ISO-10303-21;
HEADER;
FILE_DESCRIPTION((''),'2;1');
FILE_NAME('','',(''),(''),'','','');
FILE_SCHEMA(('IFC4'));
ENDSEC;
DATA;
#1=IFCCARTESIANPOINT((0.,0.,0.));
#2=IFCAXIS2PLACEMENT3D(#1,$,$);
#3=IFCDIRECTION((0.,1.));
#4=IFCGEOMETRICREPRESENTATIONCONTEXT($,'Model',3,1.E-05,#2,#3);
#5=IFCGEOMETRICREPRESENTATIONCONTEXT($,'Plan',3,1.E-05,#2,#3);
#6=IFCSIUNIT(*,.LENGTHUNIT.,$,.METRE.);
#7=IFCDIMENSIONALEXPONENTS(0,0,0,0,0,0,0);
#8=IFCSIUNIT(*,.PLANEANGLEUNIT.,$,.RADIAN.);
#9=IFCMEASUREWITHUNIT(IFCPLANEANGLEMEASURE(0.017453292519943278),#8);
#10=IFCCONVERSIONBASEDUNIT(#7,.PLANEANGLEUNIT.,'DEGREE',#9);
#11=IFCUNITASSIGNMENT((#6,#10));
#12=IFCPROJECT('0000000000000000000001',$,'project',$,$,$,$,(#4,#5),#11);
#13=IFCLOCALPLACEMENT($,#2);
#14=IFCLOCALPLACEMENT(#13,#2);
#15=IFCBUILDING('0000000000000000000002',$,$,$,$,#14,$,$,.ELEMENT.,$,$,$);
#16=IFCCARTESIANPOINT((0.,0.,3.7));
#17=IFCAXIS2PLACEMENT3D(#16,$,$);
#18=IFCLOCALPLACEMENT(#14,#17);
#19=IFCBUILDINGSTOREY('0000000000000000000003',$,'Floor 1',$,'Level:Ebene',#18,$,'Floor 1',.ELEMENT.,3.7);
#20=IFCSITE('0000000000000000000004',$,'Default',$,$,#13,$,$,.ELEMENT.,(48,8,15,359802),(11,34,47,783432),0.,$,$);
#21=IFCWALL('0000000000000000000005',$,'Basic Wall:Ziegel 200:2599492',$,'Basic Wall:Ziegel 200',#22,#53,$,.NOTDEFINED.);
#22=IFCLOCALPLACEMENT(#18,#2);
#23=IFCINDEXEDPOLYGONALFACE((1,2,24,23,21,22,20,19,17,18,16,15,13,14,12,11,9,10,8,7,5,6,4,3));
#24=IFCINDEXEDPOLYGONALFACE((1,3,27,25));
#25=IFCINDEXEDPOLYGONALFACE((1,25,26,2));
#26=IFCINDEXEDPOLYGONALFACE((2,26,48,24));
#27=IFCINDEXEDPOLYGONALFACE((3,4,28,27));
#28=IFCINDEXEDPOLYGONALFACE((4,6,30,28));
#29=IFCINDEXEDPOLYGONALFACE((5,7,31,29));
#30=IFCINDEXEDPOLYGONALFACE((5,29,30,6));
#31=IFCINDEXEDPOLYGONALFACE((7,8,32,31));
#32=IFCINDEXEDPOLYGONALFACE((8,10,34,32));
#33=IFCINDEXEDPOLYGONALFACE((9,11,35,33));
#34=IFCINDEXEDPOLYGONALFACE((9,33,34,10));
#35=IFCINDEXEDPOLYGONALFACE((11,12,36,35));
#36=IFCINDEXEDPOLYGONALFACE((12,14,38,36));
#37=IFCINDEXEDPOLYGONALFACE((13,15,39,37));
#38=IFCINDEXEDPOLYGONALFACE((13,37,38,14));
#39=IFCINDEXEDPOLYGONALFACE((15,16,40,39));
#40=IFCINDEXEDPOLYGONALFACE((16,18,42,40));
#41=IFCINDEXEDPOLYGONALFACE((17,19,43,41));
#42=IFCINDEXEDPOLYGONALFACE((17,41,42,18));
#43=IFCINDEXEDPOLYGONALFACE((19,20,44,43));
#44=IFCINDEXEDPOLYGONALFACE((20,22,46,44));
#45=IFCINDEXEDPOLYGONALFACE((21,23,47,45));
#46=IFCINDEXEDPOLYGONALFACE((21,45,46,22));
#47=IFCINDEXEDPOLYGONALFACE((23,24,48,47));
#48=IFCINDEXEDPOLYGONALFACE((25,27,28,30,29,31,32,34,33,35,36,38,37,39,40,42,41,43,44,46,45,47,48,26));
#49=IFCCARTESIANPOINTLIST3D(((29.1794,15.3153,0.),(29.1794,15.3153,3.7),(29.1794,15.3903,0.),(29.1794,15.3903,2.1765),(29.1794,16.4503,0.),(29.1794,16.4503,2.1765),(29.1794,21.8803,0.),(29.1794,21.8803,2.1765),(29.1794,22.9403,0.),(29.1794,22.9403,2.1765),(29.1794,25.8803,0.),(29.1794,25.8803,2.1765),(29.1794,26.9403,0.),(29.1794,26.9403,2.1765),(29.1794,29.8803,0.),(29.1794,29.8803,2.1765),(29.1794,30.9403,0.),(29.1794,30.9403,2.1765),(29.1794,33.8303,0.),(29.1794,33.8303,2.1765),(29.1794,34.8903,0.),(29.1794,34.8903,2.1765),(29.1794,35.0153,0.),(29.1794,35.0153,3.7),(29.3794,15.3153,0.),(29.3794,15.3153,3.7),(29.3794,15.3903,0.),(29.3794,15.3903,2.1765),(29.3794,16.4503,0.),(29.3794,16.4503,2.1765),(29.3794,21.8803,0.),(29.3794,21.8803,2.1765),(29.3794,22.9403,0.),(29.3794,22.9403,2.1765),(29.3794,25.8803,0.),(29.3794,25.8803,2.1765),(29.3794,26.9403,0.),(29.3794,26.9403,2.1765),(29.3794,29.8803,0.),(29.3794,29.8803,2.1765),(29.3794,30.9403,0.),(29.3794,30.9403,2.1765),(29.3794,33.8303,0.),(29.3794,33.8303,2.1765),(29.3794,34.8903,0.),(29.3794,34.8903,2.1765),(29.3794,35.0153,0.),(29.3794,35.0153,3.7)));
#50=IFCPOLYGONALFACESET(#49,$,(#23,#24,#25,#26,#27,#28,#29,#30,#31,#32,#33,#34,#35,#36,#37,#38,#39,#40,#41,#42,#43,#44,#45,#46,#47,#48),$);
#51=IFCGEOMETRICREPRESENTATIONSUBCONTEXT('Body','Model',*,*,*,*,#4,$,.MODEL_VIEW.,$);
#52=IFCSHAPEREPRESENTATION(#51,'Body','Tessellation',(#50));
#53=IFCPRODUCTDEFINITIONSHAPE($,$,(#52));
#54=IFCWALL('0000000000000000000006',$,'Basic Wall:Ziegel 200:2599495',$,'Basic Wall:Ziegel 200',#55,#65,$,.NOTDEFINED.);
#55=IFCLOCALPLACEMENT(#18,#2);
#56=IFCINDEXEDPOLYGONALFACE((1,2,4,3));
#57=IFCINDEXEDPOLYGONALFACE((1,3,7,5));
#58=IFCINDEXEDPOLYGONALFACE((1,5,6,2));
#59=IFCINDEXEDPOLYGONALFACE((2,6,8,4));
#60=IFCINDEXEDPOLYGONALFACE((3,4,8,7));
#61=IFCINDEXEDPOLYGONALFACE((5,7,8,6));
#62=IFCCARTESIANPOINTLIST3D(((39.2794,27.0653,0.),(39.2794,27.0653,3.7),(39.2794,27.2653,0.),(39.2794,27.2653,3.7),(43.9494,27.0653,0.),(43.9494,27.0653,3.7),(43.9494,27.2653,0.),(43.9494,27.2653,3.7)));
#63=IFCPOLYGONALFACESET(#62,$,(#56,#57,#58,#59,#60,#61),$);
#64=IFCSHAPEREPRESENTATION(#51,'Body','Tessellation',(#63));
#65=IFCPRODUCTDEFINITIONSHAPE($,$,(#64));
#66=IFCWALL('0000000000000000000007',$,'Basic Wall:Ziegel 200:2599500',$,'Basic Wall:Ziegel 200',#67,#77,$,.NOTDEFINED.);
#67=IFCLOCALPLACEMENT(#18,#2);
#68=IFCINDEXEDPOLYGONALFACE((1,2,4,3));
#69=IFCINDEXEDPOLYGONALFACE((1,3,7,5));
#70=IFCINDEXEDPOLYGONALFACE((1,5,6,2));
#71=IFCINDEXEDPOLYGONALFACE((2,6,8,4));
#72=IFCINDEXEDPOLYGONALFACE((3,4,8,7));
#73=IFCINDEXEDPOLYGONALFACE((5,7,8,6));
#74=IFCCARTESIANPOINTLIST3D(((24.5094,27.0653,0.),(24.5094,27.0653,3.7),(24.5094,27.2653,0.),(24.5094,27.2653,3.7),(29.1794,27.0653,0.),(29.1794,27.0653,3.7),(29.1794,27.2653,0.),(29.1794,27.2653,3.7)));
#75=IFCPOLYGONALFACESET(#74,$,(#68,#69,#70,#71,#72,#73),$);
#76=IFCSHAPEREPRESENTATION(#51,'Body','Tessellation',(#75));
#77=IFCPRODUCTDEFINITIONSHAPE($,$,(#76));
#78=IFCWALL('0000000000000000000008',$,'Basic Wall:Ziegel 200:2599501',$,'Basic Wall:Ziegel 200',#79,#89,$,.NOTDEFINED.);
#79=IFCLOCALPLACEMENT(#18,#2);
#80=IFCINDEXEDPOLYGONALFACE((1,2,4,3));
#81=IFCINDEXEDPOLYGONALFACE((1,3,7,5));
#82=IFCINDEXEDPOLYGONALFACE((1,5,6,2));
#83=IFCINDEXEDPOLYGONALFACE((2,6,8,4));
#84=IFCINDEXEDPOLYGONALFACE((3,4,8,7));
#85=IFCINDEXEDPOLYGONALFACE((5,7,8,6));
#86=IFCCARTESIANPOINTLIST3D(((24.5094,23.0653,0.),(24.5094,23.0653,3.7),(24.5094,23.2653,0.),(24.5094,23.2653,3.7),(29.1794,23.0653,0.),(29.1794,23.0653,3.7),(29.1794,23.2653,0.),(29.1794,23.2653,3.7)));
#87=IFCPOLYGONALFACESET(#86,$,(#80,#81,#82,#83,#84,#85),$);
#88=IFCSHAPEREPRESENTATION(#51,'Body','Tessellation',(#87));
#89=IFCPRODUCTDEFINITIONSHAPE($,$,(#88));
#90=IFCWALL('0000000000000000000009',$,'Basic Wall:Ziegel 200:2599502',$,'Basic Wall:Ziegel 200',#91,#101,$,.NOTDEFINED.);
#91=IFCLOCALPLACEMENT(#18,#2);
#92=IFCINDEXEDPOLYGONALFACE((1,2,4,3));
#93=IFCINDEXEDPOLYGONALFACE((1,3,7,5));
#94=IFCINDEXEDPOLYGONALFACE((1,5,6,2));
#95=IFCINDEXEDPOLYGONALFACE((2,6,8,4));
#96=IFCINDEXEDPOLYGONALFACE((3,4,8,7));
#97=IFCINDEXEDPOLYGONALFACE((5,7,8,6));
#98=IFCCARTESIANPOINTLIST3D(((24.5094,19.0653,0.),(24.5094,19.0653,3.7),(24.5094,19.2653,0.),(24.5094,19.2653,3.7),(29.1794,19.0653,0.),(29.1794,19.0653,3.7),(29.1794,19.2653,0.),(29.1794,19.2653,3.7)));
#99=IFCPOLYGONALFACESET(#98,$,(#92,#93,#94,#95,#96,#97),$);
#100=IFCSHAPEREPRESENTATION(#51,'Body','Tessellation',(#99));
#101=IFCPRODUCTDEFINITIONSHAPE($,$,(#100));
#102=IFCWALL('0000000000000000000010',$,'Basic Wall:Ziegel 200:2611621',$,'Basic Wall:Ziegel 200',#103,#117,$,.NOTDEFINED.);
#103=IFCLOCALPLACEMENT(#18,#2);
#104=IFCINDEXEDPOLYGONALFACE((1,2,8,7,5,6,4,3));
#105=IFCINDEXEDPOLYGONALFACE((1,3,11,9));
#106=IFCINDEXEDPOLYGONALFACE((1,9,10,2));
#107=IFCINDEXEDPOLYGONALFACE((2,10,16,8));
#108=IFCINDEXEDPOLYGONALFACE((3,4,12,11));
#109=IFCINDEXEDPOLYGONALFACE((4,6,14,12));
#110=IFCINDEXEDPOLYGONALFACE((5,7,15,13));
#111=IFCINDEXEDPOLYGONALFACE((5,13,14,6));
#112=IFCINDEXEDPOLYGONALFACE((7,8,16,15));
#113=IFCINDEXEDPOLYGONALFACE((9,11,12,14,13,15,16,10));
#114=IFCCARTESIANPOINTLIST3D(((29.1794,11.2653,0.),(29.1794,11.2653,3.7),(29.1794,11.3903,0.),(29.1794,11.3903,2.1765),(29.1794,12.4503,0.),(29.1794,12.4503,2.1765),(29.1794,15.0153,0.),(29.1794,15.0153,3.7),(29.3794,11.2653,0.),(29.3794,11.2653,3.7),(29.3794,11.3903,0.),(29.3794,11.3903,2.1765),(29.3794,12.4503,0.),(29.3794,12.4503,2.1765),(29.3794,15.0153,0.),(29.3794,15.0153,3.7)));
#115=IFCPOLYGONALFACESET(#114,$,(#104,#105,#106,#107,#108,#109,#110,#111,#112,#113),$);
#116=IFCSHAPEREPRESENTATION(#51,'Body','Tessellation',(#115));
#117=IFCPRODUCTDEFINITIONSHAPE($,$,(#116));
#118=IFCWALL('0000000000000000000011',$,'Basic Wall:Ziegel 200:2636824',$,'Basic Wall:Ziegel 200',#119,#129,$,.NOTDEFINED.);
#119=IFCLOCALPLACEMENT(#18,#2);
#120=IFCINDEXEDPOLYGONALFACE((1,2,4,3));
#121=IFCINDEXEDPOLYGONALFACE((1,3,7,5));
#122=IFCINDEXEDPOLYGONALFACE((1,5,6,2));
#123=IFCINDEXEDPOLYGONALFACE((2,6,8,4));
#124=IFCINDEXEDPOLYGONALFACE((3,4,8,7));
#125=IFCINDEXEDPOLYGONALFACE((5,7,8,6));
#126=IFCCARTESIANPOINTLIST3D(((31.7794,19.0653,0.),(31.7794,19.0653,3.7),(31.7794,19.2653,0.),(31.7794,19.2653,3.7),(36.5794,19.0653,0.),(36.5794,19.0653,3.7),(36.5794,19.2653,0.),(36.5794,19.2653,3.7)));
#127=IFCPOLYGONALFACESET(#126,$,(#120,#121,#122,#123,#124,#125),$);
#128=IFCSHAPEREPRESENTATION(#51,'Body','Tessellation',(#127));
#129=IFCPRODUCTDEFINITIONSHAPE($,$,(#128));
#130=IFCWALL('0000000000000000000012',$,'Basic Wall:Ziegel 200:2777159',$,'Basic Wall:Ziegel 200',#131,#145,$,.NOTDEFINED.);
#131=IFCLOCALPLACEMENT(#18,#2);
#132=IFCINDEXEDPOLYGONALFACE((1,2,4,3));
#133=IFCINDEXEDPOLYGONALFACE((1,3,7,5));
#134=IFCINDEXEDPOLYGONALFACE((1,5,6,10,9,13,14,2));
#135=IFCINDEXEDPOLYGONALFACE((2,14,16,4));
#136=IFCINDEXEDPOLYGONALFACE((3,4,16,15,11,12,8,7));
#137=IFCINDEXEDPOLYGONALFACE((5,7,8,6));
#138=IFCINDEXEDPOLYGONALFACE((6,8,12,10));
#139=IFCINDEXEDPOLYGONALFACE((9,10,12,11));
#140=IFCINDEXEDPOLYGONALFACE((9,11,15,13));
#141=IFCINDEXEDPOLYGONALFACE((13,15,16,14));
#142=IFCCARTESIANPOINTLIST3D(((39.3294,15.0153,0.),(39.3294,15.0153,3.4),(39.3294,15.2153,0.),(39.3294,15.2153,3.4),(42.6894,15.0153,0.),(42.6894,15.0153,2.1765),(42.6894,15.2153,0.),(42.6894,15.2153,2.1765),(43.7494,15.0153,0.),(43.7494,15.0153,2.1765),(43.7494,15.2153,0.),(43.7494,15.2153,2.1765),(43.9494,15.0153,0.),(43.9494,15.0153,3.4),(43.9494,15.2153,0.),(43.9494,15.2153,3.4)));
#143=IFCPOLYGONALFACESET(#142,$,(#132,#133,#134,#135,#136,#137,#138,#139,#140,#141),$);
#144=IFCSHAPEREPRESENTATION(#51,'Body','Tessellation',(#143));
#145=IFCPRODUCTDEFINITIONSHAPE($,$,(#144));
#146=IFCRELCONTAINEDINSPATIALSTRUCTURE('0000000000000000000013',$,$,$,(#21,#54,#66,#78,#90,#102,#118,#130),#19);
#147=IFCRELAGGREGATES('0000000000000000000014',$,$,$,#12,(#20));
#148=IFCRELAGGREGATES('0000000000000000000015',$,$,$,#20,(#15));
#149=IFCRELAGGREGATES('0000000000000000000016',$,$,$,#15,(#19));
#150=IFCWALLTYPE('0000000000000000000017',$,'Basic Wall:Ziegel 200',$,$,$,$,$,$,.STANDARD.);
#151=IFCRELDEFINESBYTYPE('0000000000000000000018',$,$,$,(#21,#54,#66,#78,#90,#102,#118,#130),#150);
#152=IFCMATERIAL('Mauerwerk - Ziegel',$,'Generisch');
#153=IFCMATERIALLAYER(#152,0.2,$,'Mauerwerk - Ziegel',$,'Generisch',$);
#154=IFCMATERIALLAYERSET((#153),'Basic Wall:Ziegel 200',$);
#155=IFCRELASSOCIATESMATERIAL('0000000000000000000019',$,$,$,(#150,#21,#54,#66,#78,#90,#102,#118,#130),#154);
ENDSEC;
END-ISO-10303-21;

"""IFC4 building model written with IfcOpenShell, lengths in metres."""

from ifc_helpers import new_model, entity, si_unit, converted_unit, direction, frame, frame_2d, origin, place, context, subcontext, project, spatial, polyline, rectangle, extrude, clip, bounded_halfspace, material, layer, layer_set, layer_usage, type_object, element, save


model = new_model("IFC4")

# Units and contexts
model_context = context("Model", 3, precision=1e-05, world=origin(), true_north=direction((0.0, 1.0)))
plan_context = context("Plan", 3, precision=1e-05, world=origin(), true_north=direction((0.0, 1.0)))
body_context = subcontext(model_context, "Body", "Model", "MODEL_VIEW")
ifc_project = project(units=[si_unit("LENGTHUNIT", "METRE"), converted_unit("PLANEANGLEUNIT", "DEGREE", entity("IfcPlaneAngleMeasure", 0.017453292519943278), si_unit("PLANEANGLEUNIT", "RADIAN"), dimensions=[0, 0, 0, 0, 0, 0, 0])], contexts=[model_context, plan_context])

# Site, building, storey
site_placement = place(None, origin())
site = spatial("IfcSite", under=ifc_project, at=site_placement, Name="Default", CompositionType="ELEMENT", RefLatitude=(48, 8, 15, 359802), RefLongitude=(11, 34, 47, 783432), RefElevation=0.0)
building_placement = place(site_placement, origin())
building = spatial("IfcBuilding", under=site, at=building_placement, CompositionType="ELEMENT")
storey_placement = place(building_placement, frame((0.0, 0.0, 3.7)))
storey = spatial("IfcBuildingStorey", under=building, at=storey_placement, Name="Floor 1", ObjectType="Level:Ebene", LongName="Floor 1", CompositionType="ELEMENT", Elevation=3.7)

# Shared definitions
ifc_material_1 = material(Name="Mauerwerk - Ziegel", Category="Generisch")
ifc_layer_1 = layer(ifc_material_1, 0.2, Name="Mauerwerk - Ziegel", Category="Generisch")
ifc_layer_set_1 = layer_set([ifc_layer_1], Name="Basic Wall:Ziegel 200")
ifc_layer_usage_1 = layer_usage(ifc_layer_set_1, "AXIS2", "NEGATIVE", 0.1)
wall_type_1 = type_object("IfcWallType", Name="Basic Wall:Ziegel 200", PredefinedType="STANDARD", material=ifc_layer_set_1)

# Wall, openings
wall_1_placement = place(storey_placement, frame((29.2794, 15.3153, 0.0), z_axis=(0.0, 0.0, 1.0), x_axis=(0.0, 1.0, 0.0)))
wall_1 = element("IfcWall", 1, at=wall_1_placement, inside=storey, type_object=wall_type_1, material=ifc_layer_usage_1, Name="Basic Wall:Ziegel 200:2599492", ObjectType="Basic Wall:Ziegel 200", PredefinedType="NOTDEFINED", context=body_context, shape_type="SweptSolid", body=[
    extrude(rectangle(XDim=19.7, YDim=0.2, at=frame_2d((9.85, 0.0), x_axis=(1.0, 0.0))), origin(), (0.0, 0.0, 1.0), 3.7),
])
opening_1_placement = place(wall_1_placement, frame((15.625, 0.1, 0.0)))
element("IfcOpeningElement", 2, at=opening_1_placement, cuts=wall_1, PredefinedType="OPENING", context=body_context, shape_type="SweptSolid", body=[
    extrude(rectangle(XDim=2.1765, YDim=1.06, at=frame_2d((1.0882, 0.53), x_axis=(1.0, 0.0))), frame((0.0, 0.0, 0.0), z_axis=(0.0, -1.0, 0.0), x_axis=(0.0, 0.0, 1.0)), (0.0, 0.0, 1.0), 0.2),
])
opening_2_placement = place(wall_1_placement, frame((11.625, 0.1, 0.0)))
element("IfcOpeningElement", 3, at=opening_2_placement, cuts=wall_1, PredefinedType="OPENING", context=body_context, shape_type="SweptSolid", body=[
    extrude(rectangle(XDim=2.1765, YDim=1.06, at=frame_2d((1.0882, 0.53), x_axis=(1.0, 0.0))), frame((0.0, 0.0, 0.0), z_axis=(0.0, -1.0, 0.0), x_axis=(0.0, 0.0, 1.0)), (0.0, 0.0, 1.0), 0.2),
])
opening_3_placement = place(wall_1_placement, frame((7.625, 0.1, 0.0)))
element("IfcOpeningElement", 4, at=opening_3_placement, cuts=wall_1, PredefinedType="OPENING", context=body_context, shape_type="SweptSolid", body=[
    extrude(rectangle(XDim=2.1765, YDim=1.06, at=frame_2d((1.0882, 0.53), x_axis=(1.0, 0.0))), frame((0.0, 0.0, 0.0), z_axis=(0.0, -1.0, 0.0), x_axis=(0.0, 0.0, 1.0)), (0.0, 0.0, 1.0), 0.2),
])
opening_4_placement = place(wall_1_placement, frame((1.135, 0.1, 0.0)))
element("IfcOpeningElement", 5, at=opening_4_placement, cuts=wall_1, PredefinedType="OPENING", context=body_context, shape_type="SweptSolid", body=[
    extrude(rectangle(XDim=2.1765, YDim=1.06, at=frame_2d((1.0882, 0.53), x_axis=(1.0, 0.0))), frame((0.0, 0.0, 0.0), z_axis=(0.0, -1.0, 0.0), x_axis=(0.0, 0.0, 1.0)), (0.0, 0.0, 1.0), 0.2),
])
opening_5_placement = place(wall_1_placement, frame((19.575, 0.1, 0.0)))
element("IfcOpeningElement", 6, at=opening_5_placement, cuts=wall_1, PredefinedType="OPENING", context=body_context, shape_type="SweptSolid", body=[
    extrude(rectangle(XDim=2.1765, YDim=1.06, at=frame_2d((1.0882, 0.53), x_axis=(1.0, 0.0))), frame((0.0, 0.0, 0.0), z_axis=(0.0, -1.0, 0.0), x_axis=(0.0, 0.0, 1.0)), (0.0, 0.0, 1.0), 0.2),
])

# Walls
wall_2_placement = place(storey_placement, frame((39.2794, 27.1653, 0.0)))
element("IfcWall", 7, at=wall_2_placement, inside=storey, type_object=wall_type_1, material=ifc_layer_usage_1, Name="Basic Wall:Ziegel 200:2599495", ObjectType="Basic Wall:Ziegel 200", PredefinedType="NOTDEFINED", context=body_context, shape_type="SweptSolid", body=[
    extrude(rectangle(XDim=4.67, YDim=0.2, at=frame_2d((2.335, 0.0), x_axis=(-1.0, 0.0))), origin(), (0.0, 0.0, 1.0), 3.7),
])
wall_3_placement = place(storey_placement, frame((29.1794, 27.1653, 0.0), z_axis=(0.0, 0.0, 1.0), x_axis=(-1.0, 0.0, 0.0)))
element("IfcWall", 8, at=wall_3_placement, inside=storey, type_object=wall_type_1, material=ifc_layer_usage_1, Name="Basic Wall:Ziegel 200:2599500", ObjectType="Basic Wall:Ziegel 200", PredefinedType="NOTDEFINED", context=body_context, shape_type="SweptSolid", body=[
    extrude(rectangle(XDim=4.67, YDim=0.2, at=frame_2d((2.335, 0.0), x_axis=(-1.0, 0.0))), origin(), (0.0, 0.0, 1.0), 3.7),
])
wall_4_placement = place(storey_placement, frame((29.1794, 23.1653, 0.0), z_axis=(0.0, 0.0, 1.0), x_axis=(-1.0, 0.0, 0.0)))
element("IfcWall", 9, at=wall_4_placement, inside=storey, type_object=wall_type_1, material=ifc_layer_usage_1, Name="Basic Wall:Ziegel 200:2599501", ObjectType="Basic Wall:Ziegel 200", PredefinedType="NOTDEFINED", context=body_context, shape_type="SweptSolid", body=[
    extrude(rectangle(XDim=4.67, YDim=0.2, at=frame_2d((2.335, 0.0), x_axis=(-1.0, 0.0))), origin(), (0.0, 0.0, 1.0), 3.7),
])
wall_5_placement = place(storey_placement, frame((29.1794, 19.1653, 0.0), z_axis=(0.0, 0.0, 1.0), x_axis=(-1.0, 0.0, 0.0)))
element("IfcWall", 10, at=wall_5_placement, inside=storey, type_object=wall_type_1, material=ifc_layer_usage_1, Name="Basic Wall:Ziegel 200:2599502", ObjectType="Basic Wall:Ziegel 200", PredefinedType="NOTDEFINED", context=body_context, shape_type="SweptSolid", body=[
    extrude(rectangle(XDim=4.67, YDim=0.2, at=frame_2d((2.335, 0.0), x_axis=(-1.0, 0.0))), origin(), (0.0, 0.0, 1.0), 3.7),
])

# Wall, opening
wall_6_placement = place(storey_placement, frame((29.2794, 15.0153, 0.0), z_axis=(0.0, 0.0, 1.0), x_axis=(0.0, -1.0, 0.0)))
wall_6 = element("IfcWall", 11, at=wall_6_placement, inside=storey, type_object=wall_type_1, material=ifc_layer_usage_1, Name="Basic Wall:Ziegel 200:2611621", ObjectType="Basic Wall:Ziegel 200", PredefinedType="NOTDEFINED", context=body_context, shape_type="SweptSolid", body=[
    extrude(rectangle(XDim=3.75, YDim=0.2, at=frame_2d((1.875, 0.0), x_axis=(-1.0, 0.0))), origin(), (0.0, 0.0, 1.0), 3.7),
])
opening_6_placement = place(wall_6_placement, frame((2.565, -0.1, 0.0)))
element("IfcOpeningElement", 12, at=opening_6_placement, cuts=wall_6, PredefinedType="OPENING", context=body_context, shape_type="SweptSolid", body=[
    extrude(rectangle(XDim=2.1765, YDim=1.06, at=frame_2d((1.0882, 0.53), x_axis=(1.0, 0.0))), frame((0.0, 0.0, 0.0), z_axis=(0.0, 1.0, 0.0), x_axis=(0.0, 0.0, 1.0)), (0.0, 0.0, 1.0), 0.2),
])

# Wall
wall_7_placement = place(storey_placement, frame((31.7794, 19.1653, 0.0)))
element("IfcWall", 13, at=wall_7_placement, inside=storey, type_object=wall_type_1, material=ifc_layer_usage_1, Name="Basic Wall:Ziegel 200:2636824", ObjectType="Basic Wall:Ziegel 200", PredefinedType="NOTDEFINED", context=body_context, shape_type="SweptSolid", body=[
    extrude(rectangle(XDim=4.8, YDim=0.2, at=frame_2d((2.4, 0.0), x_axis=(-1.0, 0.0))), origin(), (0.0, 0.0, 1.0), 3.7),
])

# Wall, opening
ifc_layer_usage_2 = layer_usage(ifc_layer_set_1, "AXIS2", "POSITIVE", -0.1)
wall_8_placement = place(storey_placement, frame((39.3294, 15.1153, 0.0)))
wall_8 = element("IfcWall", 14, at=wall_8_placement, inside=storey, type_object=wall_type_1, material=ifc_layer_usage_2, Name="Basic Wall:Ziegel 200:2777159", ObjectType="Basic Wall:Ziegel 200", PredefinedType="NOTDEFINED", context=body_context, shape_type="Clipping", body=[
    clip(extrude(rectangle(XDim=4.62, YDim=0.2, at=frame_2d((2.31, 0.0), x_axis=(-1.0, 0.0))), origin(), (0.0, 0.0, 1.0), 3.4), bounded_halfspace(frame((0.0, -0.1, 3.4), z_axis=(0.0, 0.0, -1.0), x_axis=(-1.0, 0.0, 0.0)), True, frame((0.0, -0.1, 3.4)), polyline([(0.0, 0.0), (4.62, 0.0), (4.62, 0.2), (0.0, 0.2), (0.0, 0.0)]))),
])
opening_7_placement = place(wall_8_placement, frame((4.42, 0.1, 0.0)))
element("IfcOpeningElement", 15, at=opening_7_placement, cuts=wall_8, PredefinedType="OPENING", context=body_context, shape_type="SweptSolid", body=[
    extrude(rectangle(XDim=2.1765, YDim=1.06, at=frame_2d((1.0882, 0.53), x_axis=(1.0, 0.0))), frame((0.0, 0.0, 0.0), z_axis=(0.0, -1.0, 0.0), x_axis=(0.0, 0.0, 1.0)), (0.0, 0.0, 1.0), 0.2),
])

save(model, "model.ifc")
